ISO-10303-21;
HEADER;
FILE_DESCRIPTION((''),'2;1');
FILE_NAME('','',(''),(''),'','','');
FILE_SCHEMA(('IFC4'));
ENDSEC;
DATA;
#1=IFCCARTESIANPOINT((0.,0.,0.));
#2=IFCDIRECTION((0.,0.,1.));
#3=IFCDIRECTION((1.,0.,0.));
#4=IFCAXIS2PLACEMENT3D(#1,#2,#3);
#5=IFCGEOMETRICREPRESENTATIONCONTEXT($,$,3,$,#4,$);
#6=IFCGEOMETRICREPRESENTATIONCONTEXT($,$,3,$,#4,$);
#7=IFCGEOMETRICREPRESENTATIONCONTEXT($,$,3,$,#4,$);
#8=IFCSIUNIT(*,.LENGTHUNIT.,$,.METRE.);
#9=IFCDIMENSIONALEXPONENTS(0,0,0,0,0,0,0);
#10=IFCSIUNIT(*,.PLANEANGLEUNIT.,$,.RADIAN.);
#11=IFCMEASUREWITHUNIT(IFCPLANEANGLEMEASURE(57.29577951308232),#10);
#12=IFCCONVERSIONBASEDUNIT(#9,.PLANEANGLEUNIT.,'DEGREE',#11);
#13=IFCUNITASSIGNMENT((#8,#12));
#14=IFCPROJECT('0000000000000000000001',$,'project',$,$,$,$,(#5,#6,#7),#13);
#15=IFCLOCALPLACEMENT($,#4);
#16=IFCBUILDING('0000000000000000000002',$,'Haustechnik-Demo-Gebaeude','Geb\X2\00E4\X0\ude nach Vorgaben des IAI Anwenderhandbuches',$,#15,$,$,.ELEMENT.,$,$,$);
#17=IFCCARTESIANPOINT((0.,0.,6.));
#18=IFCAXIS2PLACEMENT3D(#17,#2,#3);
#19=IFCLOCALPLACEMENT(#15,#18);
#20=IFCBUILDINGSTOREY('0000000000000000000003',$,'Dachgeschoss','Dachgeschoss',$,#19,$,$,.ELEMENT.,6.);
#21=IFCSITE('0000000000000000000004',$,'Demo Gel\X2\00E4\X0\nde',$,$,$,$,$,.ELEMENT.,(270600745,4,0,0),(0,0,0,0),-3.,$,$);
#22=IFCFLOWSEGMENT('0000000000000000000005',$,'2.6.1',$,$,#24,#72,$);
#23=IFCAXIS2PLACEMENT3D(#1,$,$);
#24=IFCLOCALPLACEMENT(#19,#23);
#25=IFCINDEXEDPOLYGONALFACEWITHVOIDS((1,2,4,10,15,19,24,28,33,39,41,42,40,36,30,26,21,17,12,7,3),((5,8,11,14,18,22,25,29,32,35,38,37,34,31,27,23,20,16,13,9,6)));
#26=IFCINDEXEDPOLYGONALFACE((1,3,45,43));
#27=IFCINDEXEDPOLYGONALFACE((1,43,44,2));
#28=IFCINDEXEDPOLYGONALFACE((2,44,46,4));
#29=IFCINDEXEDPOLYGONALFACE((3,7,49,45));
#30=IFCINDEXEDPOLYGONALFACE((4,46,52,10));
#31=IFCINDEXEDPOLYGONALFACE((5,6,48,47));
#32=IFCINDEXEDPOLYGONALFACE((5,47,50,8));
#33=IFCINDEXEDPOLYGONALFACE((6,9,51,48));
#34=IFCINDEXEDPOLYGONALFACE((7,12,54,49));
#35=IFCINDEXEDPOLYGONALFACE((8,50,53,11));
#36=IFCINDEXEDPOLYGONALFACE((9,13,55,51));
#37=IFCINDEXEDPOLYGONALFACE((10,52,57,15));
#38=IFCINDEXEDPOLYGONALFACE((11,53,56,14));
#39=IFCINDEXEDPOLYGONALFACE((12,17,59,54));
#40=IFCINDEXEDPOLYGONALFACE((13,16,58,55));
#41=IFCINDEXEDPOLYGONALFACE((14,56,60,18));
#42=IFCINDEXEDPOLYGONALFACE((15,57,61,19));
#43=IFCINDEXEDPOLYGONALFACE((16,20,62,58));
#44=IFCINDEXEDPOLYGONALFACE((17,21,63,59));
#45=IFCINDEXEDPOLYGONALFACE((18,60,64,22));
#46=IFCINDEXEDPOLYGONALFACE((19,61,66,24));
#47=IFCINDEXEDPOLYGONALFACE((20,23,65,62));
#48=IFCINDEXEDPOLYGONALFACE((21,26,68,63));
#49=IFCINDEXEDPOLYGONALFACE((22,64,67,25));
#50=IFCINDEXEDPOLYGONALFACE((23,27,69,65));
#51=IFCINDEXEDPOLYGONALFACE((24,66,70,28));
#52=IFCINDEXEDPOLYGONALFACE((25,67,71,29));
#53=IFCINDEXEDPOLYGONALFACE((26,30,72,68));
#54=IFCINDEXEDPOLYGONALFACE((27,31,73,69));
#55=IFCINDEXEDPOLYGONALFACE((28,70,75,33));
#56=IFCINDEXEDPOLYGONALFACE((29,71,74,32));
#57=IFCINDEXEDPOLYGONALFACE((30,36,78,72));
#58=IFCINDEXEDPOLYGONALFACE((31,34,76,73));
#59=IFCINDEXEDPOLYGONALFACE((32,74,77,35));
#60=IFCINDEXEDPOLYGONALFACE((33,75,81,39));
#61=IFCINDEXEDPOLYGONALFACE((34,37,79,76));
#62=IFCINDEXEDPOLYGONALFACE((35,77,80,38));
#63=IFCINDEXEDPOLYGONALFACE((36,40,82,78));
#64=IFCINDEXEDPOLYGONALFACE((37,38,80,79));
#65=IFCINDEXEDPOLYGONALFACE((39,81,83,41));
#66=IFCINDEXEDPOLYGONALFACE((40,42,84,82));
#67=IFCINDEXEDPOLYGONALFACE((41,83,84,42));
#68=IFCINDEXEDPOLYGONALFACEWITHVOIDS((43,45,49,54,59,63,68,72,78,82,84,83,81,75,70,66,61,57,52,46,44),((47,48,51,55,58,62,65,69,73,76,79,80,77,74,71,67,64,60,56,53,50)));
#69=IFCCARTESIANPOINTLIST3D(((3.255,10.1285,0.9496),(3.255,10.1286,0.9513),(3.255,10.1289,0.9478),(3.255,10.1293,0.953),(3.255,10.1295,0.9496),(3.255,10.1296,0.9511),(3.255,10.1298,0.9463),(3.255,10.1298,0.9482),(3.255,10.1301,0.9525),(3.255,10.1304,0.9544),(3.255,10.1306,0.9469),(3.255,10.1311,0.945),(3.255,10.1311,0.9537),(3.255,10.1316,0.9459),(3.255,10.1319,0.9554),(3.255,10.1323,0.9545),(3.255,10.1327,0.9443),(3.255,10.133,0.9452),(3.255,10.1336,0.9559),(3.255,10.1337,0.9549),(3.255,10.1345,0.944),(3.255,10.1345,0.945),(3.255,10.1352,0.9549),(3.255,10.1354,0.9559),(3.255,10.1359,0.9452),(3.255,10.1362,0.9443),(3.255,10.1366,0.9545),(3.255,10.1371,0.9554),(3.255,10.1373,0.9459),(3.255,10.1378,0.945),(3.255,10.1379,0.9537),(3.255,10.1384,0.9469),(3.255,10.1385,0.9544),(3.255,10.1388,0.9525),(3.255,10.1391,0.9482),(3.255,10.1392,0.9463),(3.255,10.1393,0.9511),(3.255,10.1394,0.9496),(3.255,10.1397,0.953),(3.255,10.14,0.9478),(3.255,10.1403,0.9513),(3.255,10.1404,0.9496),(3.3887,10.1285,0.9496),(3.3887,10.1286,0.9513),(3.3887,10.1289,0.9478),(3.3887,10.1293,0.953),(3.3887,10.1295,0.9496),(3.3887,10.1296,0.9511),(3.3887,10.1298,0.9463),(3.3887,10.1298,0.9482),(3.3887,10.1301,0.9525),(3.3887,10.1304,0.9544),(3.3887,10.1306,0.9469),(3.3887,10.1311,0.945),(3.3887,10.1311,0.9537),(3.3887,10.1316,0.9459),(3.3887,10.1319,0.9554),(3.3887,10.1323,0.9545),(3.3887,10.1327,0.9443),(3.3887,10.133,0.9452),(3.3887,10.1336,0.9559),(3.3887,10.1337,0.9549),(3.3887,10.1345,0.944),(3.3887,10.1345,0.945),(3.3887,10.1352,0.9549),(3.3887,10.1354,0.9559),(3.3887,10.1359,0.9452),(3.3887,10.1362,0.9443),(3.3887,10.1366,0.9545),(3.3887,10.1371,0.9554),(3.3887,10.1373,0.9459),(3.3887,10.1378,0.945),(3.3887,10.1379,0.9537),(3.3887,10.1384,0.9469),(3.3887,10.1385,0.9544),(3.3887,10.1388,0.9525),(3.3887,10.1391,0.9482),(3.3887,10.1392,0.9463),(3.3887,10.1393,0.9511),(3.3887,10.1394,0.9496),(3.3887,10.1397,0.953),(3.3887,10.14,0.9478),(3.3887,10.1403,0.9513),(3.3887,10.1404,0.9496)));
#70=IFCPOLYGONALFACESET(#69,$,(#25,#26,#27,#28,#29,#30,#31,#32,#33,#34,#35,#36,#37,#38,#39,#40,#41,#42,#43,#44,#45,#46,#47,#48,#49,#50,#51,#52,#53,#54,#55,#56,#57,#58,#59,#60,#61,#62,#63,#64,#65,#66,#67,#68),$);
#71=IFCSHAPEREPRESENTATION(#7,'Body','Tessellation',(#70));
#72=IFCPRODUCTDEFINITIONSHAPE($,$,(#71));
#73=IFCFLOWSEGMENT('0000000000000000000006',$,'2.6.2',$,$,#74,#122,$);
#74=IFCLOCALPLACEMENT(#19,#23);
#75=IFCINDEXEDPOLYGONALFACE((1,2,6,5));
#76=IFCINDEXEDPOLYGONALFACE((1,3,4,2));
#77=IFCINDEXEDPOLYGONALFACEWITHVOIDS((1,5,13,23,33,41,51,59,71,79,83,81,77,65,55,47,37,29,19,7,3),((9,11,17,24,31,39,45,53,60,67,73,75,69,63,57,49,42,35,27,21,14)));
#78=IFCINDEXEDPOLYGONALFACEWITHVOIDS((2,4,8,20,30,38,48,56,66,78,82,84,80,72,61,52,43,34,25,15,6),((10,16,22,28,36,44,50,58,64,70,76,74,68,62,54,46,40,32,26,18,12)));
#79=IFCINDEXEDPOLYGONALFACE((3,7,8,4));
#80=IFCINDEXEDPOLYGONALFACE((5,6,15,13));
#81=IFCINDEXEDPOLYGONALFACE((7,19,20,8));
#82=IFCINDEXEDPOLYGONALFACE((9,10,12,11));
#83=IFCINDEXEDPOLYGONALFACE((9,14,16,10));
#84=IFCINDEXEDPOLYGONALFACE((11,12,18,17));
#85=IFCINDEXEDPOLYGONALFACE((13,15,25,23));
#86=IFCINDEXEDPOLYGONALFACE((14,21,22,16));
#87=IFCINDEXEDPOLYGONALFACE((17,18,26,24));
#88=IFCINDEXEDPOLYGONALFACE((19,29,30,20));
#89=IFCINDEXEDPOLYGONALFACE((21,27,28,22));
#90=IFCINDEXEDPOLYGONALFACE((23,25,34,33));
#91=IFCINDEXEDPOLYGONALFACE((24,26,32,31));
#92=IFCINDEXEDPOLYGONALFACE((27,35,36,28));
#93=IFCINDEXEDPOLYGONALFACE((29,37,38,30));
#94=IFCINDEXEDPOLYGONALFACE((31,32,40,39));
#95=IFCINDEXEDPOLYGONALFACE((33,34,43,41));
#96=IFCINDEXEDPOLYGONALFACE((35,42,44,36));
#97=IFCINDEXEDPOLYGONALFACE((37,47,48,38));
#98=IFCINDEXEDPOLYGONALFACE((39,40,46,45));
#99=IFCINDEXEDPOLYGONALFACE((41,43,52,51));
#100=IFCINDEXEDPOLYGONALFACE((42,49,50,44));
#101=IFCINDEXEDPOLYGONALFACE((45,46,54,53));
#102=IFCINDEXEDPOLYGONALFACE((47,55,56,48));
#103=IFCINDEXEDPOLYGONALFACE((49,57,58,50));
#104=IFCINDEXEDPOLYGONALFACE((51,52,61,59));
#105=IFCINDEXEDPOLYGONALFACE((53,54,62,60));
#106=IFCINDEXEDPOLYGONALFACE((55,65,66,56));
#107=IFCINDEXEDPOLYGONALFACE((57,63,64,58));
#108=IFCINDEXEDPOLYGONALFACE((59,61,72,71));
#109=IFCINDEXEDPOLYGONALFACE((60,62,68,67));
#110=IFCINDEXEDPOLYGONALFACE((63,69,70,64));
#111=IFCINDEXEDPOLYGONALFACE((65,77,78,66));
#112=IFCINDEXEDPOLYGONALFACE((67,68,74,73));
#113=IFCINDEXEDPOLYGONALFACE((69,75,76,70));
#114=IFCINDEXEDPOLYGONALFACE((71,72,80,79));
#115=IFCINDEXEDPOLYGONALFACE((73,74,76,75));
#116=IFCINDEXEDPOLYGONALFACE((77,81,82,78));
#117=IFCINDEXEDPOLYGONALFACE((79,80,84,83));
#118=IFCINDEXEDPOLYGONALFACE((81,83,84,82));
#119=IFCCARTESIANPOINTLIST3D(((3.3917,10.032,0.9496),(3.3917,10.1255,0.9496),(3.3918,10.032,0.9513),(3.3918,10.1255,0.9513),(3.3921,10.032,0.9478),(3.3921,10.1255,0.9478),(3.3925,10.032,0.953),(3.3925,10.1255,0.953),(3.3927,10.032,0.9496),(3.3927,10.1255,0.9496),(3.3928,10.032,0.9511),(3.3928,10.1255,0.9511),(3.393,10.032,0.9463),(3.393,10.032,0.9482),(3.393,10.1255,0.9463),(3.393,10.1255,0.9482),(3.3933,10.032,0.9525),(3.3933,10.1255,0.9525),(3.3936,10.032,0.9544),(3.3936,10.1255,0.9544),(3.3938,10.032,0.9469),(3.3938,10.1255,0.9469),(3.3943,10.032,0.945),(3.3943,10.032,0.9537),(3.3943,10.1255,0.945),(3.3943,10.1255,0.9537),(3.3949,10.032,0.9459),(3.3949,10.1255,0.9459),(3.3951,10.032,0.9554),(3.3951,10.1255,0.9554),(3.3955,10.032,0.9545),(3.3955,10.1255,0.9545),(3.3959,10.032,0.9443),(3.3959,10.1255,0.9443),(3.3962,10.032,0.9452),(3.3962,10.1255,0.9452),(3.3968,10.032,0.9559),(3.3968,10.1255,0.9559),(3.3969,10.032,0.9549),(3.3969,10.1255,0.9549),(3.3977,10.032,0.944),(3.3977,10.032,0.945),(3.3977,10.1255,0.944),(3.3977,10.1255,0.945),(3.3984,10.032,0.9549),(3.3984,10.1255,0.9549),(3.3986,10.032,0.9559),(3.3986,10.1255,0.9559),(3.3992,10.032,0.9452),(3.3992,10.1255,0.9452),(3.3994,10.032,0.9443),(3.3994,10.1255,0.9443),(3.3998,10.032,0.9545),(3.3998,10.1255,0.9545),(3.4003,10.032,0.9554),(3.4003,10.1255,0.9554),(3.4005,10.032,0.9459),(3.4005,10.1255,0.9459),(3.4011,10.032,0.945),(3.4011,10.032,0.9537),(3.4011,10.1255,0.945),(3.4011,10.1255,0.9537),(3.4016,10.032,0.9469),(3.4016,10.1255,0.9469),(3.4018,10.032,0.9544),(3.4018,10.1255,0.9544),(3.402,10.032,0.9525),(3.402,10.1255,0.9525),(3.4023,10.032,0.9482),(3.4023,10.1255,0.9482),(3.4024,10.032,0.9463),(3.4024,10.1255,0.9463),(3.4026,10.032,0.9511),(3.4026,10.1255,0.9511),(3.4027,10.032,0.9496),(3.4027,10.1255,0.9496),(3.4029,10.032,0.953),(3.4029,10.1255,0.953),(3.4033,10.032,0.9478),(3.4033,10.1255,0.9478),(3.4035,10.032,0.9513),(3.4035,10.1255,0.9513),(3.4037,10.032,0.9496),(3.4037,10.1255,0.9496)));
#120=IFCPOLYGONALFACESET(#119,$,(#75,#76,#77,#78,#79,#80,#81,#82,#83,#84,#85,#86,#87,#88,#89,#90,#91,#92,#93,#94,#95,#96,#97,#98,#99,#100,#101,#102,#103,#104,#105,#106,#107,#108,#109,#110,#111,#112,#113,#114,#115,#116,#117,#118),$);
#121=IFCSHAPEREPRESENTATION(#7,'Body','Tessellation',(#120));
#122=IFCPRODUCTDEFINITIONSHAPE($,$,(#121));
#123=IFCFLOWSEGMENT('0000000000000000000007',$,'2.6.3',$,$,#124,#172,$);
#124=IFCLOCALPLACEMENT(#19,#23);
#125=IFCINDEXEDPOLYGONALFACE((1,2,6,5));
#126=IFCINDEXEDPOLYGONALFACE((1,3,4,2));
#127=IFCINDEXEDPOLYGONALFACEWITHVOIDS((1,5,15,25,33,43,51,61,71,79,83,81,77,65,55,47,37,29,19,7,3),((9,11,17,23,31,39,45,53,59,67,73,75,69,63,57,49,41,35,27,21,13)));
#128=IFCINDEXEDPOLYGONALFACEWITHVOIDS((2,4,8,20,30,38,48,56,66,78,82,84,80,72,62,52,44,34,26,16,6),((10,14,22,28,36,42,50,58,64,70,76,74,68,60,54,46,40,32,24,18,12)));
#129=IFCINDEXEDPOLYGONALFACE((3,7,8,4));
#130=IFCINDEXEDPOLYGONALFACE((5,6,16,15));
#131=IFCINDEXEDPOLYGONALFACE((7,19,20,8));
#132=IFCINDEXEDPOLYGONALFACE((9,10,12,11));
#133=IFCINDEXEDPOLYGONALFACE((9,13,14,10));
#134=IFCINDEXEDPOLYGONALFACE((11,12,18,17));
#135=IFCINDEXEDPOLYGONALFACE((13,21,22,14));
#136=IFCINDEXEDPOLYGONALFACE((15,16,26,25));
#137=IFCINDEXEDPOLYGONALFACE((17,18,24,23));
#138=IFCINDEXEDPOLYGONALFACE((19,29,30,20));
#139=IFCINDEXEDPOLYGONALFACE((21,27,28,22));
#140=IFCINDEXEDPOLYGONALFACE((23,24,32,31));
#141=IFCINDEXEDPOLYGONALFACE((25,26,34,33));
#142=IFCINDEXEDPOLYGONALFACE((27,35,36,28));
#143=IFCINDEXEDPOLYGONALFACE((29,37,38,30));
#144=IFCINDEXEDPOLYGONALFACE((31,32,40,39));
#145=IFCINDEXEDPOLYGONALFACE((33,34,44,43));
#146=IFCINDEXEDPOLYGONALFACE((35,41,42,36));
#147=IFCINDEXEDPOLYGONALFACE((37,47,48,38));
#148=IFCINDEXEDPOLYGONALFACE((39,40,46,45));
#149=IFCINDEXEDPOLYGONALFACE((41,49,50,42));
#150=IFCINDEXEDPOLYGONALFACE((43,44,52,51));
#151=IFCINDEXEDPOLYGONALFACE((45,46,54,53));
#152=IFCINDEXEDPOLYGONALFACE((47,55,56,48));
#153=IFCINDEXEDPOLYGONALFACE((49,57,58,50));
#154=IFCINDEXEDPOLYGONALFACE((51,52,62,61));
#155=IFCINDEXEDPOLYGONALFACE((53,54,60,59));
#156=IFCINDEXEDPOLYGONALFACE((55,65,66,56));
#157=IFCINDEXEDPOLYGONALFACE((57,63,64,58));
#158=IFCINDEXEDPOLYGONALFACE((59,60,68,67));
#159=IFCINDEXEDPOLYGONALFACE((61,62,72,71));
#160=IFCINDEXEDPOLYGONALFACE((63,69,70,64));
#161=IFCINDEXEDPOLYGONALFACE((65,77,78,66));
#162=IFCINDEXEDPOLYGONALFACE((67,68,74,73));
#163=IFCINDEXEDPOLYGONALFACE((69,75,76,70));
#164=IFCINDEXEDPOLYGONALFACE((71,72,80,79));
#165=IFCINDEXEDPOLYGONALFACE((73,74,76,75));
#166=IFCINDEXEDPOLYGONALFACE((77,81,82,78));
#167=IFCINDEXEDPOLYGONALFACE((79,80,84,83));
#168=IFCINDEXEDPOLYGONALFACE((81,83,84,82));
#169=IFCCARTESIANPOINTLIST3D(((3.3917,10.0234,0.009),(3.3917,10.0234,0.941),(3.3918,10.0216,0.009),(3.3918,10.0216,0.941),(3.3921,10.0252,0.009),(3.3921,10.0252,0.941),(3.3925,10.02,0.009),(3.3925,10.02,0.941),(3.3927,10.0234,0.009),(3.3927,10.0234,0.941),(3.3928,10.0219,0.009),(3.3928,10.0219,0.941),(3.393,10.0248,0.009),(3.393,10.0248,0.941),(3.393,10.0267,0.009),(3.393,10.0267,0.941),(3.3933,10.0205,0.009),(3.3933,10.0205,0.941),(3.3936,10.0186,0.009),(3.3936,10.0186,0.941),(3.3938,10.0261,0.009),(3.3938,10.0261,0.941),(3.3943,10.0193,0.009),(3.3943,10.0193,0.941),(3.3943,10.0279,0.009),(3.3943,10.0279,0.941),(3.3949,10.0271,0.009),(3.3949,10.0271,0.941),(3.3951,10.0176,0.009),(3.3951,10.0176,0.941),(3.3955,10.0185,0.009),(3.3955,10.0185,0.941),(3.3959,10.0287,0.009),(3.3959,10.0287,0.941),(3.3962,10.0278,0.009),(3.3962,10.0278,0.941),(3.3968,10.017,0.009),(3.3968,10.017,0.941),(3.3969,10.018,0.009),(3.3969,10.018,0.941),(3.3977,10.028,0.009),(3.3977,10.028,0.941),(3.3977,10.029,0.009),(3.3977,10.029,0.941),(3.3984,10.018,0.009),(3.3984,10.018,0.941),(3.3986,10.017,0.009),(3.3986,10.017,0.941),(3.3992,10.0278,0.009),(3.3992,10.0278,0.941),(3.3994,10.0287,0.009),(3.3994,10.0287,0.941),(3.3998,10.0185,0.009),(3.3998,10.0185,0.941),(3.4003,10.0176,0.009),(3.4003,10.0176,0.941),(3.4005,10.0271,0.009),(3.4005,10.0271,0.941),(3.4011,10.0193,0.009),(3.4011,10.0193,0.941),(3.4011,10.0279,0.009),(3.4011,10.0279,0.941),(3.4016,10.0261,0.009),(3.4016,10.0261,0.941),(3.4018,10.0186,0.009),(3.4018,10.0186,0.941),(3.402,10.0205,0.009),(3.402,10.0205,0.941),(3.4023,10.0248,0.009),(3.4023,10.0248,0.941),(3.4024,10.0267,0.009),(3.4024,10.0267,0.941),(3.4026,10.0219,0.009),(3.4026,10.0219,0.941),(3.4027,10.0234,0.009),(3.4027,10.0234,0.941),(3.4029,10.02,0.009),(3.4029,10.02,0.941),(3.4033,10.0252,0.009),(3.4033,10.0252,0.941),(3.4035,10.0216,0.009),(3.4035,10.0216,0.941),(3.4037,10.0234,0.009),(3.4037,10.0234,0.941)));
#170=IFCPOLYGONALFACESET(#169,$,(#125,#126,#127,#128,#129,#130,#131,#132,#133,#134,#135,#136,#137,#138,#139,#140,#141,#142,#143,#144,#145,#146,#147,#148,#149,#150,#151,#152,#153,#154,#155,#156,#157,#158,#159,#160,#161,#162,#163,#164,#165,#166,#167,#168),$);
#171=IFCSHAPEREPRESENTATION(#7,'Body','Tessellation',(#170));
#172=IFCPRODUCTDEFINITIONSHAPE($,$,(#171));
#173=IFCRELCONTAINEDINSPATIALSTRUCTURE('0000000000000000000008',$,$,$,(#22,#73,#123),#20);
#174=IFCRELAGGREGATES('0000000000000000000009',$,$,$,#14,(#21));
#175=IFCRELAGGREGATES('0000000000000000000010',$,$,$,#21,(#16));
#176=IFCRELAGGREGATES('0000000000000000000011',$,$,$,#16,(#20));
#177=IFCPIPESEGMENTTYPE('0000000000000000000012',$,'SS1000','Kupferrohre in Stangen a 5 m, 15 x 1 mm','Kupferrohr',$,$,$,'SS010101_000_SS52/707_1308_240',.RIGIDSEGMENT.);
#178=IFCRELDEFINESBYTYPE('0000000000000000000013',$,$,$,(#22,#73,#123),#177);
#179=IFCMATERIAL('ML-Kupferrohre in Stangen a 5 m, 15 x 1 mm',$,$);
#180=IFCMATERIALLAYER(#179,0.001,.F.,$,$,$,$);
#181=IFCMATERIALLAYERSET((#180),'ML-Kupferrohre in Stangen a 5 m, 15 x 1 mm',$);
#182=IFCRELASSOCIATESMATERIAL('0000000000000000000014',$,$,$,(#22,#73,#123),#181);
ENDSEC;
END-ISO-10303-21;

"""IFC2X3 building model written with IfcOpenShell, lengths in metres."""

from ifc_helpers import new_model, entity, si_unit, converted_unit, frame, origin_with_axes, origin_2d_with_axis, place, context, project, spatial, hollow_circle, extrude, material, layer, layer_set, layer_usage, type_object, element, save


model = new_model("IFC2X3")

# Units and contexts
context_of_model_1 = context(None, 3, world=origin_with_axes())
context_of_model_2 = context(None, 3, world=origin_with_axes())
context_of_model_3 = context(None, 3, world=origin_with_axes())
ifc_project = project(units=[si_unit("LENGTHUNIT", "METRE"), converted_unit("PLANEANGLEUNIT", "DEGREE", entity("IfcPlaneAngleMeasure", 57.29577951308232), si_unit("PLANEANGLEUNIT", "RADIAN"), dimensions=[0, 0, 0, 0, 0, 0, 0])], contexts=[context_of_model_1, context_of_model_2, context_of_model_3])

# Site, building, storey
site = spatial("IfcSite", under=ifc_project, Name="Demo Gelände", CompositionType="ELEMENT", RefLatitude=(270600745, 4, 0, 0), RefLongitude=(0, 0, 0, 0), RefElevation=-3.0)
building_placement = place(None, origin_with_axes())
building = spatial("IfcBuilding", under=site, at=building_placement, Name="Haustechnik-Demo-Gebaeude", Description="Gebäude nach Vorgaben des IAI Anwenderhandbuches", CompositionType="ELEMENT")
storey_placement = place(building_placement, frame((0.0, 0.0, 6.0), z_axis=(0.0, 0.0, 1.0), x_axis=(1.0, 0.0, 0.0)))
storey = spatial("IfcBuildingStorey", under=building, at=storey_placement, Name="Dachgeschoss", Description="Dachgeschoss", CompositionType="ELEMENT", Elevation=6.0)

# Flow segments
ifc_material = material(Name="ML-Kupferrohre in Stangen a 5 m, 15 x 1 mm")
ifc_layer = layer(ifc_material, 0.001, ventilated=False)
ifc_layer_set = layer_set([ifc_layer], Name="ML-Kupferrohre in Stangen a 5 m, 15 x 1 mm")
ifc_layer_usage = layer_usage(ifc_layer_set, "AXIS2", "POSITIVE", 0.0)
pipe_segment_type_1 = type_object("IfcPipeSegmentType", Name="SS1000", Description="Kupferrohre in Stangen a 5 m, 15 x 1 mm", ApplicableOccurrence="Kupferrohr", ElementType="SS010101_000_SS52/707_1308_240", PredefinedType="RIGIDSEGMENT")
flow_segment_1_placement = place(storey_placement, frame((3.255, 10.1345, 0.95), z_axis=(1.0, 0.0, 0.0), x_axis=(0.0, 0.0, -1.0)))
element("IfcFlowSegment", 1, at=flow_segment_1_placement, inside=storey, type_object=pipe_segment_type_1, material=ifc_layer_usage, Name="2.6.1", context=context_of_model_3, shape_type="SweptSolid", body=[
    extrude(hollow_circle(Radius=0.006, WallThickness=0.001, at=origin_2d_with_axis()), origin_with_axes(), (0.0, 0.0, 1.0), 0.1337),
])
flow_segment_2_placement = place(storey_placement, frame((3.3977, 10.1255, 0.95), z_axis=(0.0, -1.0, 0.0), x_axis=(0.0, 0.0, -1.0)))
element("IfcFlowSegment", 2, at=flow_segment_2_placement, inside=storey, type_object=pipe_segment_type_1, material=ifc_layer_usage, Name="2.6.2", context=context_of_model_3, shape_type="SweptSolid", body=[
    extrude(hollow_circle(Radius=0.006, WallThickness=0.001, at=origin_2d_with_axis()), origin_with_axes(), (0.0, 0.0, 1.0), 0.0935),
])
flow_segment_3_placement = place(storey_placement, frame((3.3977, 10.023, 0.941), z_axis=(0.0, 0.0, -1.0), x_axis=(0.0, 1.0, 0.0)))
element("IfcFlowSegment", 3, at=flow_segment_3_placement, inside=storey, type_object=pipe_segment_type_1, material=ifc_layer_usage, Name="2.6.3", context=context_of_model_3, shape_type="SweptSolid", body=[
    extrude(hollow_circle(Radius=0.006, WallThickness=0.001, at=origin_2d_with_axis()), origin_with_axes(), (0.0, 0.0, 1.0), 0.932),
])

save(model, "model.ifc")
